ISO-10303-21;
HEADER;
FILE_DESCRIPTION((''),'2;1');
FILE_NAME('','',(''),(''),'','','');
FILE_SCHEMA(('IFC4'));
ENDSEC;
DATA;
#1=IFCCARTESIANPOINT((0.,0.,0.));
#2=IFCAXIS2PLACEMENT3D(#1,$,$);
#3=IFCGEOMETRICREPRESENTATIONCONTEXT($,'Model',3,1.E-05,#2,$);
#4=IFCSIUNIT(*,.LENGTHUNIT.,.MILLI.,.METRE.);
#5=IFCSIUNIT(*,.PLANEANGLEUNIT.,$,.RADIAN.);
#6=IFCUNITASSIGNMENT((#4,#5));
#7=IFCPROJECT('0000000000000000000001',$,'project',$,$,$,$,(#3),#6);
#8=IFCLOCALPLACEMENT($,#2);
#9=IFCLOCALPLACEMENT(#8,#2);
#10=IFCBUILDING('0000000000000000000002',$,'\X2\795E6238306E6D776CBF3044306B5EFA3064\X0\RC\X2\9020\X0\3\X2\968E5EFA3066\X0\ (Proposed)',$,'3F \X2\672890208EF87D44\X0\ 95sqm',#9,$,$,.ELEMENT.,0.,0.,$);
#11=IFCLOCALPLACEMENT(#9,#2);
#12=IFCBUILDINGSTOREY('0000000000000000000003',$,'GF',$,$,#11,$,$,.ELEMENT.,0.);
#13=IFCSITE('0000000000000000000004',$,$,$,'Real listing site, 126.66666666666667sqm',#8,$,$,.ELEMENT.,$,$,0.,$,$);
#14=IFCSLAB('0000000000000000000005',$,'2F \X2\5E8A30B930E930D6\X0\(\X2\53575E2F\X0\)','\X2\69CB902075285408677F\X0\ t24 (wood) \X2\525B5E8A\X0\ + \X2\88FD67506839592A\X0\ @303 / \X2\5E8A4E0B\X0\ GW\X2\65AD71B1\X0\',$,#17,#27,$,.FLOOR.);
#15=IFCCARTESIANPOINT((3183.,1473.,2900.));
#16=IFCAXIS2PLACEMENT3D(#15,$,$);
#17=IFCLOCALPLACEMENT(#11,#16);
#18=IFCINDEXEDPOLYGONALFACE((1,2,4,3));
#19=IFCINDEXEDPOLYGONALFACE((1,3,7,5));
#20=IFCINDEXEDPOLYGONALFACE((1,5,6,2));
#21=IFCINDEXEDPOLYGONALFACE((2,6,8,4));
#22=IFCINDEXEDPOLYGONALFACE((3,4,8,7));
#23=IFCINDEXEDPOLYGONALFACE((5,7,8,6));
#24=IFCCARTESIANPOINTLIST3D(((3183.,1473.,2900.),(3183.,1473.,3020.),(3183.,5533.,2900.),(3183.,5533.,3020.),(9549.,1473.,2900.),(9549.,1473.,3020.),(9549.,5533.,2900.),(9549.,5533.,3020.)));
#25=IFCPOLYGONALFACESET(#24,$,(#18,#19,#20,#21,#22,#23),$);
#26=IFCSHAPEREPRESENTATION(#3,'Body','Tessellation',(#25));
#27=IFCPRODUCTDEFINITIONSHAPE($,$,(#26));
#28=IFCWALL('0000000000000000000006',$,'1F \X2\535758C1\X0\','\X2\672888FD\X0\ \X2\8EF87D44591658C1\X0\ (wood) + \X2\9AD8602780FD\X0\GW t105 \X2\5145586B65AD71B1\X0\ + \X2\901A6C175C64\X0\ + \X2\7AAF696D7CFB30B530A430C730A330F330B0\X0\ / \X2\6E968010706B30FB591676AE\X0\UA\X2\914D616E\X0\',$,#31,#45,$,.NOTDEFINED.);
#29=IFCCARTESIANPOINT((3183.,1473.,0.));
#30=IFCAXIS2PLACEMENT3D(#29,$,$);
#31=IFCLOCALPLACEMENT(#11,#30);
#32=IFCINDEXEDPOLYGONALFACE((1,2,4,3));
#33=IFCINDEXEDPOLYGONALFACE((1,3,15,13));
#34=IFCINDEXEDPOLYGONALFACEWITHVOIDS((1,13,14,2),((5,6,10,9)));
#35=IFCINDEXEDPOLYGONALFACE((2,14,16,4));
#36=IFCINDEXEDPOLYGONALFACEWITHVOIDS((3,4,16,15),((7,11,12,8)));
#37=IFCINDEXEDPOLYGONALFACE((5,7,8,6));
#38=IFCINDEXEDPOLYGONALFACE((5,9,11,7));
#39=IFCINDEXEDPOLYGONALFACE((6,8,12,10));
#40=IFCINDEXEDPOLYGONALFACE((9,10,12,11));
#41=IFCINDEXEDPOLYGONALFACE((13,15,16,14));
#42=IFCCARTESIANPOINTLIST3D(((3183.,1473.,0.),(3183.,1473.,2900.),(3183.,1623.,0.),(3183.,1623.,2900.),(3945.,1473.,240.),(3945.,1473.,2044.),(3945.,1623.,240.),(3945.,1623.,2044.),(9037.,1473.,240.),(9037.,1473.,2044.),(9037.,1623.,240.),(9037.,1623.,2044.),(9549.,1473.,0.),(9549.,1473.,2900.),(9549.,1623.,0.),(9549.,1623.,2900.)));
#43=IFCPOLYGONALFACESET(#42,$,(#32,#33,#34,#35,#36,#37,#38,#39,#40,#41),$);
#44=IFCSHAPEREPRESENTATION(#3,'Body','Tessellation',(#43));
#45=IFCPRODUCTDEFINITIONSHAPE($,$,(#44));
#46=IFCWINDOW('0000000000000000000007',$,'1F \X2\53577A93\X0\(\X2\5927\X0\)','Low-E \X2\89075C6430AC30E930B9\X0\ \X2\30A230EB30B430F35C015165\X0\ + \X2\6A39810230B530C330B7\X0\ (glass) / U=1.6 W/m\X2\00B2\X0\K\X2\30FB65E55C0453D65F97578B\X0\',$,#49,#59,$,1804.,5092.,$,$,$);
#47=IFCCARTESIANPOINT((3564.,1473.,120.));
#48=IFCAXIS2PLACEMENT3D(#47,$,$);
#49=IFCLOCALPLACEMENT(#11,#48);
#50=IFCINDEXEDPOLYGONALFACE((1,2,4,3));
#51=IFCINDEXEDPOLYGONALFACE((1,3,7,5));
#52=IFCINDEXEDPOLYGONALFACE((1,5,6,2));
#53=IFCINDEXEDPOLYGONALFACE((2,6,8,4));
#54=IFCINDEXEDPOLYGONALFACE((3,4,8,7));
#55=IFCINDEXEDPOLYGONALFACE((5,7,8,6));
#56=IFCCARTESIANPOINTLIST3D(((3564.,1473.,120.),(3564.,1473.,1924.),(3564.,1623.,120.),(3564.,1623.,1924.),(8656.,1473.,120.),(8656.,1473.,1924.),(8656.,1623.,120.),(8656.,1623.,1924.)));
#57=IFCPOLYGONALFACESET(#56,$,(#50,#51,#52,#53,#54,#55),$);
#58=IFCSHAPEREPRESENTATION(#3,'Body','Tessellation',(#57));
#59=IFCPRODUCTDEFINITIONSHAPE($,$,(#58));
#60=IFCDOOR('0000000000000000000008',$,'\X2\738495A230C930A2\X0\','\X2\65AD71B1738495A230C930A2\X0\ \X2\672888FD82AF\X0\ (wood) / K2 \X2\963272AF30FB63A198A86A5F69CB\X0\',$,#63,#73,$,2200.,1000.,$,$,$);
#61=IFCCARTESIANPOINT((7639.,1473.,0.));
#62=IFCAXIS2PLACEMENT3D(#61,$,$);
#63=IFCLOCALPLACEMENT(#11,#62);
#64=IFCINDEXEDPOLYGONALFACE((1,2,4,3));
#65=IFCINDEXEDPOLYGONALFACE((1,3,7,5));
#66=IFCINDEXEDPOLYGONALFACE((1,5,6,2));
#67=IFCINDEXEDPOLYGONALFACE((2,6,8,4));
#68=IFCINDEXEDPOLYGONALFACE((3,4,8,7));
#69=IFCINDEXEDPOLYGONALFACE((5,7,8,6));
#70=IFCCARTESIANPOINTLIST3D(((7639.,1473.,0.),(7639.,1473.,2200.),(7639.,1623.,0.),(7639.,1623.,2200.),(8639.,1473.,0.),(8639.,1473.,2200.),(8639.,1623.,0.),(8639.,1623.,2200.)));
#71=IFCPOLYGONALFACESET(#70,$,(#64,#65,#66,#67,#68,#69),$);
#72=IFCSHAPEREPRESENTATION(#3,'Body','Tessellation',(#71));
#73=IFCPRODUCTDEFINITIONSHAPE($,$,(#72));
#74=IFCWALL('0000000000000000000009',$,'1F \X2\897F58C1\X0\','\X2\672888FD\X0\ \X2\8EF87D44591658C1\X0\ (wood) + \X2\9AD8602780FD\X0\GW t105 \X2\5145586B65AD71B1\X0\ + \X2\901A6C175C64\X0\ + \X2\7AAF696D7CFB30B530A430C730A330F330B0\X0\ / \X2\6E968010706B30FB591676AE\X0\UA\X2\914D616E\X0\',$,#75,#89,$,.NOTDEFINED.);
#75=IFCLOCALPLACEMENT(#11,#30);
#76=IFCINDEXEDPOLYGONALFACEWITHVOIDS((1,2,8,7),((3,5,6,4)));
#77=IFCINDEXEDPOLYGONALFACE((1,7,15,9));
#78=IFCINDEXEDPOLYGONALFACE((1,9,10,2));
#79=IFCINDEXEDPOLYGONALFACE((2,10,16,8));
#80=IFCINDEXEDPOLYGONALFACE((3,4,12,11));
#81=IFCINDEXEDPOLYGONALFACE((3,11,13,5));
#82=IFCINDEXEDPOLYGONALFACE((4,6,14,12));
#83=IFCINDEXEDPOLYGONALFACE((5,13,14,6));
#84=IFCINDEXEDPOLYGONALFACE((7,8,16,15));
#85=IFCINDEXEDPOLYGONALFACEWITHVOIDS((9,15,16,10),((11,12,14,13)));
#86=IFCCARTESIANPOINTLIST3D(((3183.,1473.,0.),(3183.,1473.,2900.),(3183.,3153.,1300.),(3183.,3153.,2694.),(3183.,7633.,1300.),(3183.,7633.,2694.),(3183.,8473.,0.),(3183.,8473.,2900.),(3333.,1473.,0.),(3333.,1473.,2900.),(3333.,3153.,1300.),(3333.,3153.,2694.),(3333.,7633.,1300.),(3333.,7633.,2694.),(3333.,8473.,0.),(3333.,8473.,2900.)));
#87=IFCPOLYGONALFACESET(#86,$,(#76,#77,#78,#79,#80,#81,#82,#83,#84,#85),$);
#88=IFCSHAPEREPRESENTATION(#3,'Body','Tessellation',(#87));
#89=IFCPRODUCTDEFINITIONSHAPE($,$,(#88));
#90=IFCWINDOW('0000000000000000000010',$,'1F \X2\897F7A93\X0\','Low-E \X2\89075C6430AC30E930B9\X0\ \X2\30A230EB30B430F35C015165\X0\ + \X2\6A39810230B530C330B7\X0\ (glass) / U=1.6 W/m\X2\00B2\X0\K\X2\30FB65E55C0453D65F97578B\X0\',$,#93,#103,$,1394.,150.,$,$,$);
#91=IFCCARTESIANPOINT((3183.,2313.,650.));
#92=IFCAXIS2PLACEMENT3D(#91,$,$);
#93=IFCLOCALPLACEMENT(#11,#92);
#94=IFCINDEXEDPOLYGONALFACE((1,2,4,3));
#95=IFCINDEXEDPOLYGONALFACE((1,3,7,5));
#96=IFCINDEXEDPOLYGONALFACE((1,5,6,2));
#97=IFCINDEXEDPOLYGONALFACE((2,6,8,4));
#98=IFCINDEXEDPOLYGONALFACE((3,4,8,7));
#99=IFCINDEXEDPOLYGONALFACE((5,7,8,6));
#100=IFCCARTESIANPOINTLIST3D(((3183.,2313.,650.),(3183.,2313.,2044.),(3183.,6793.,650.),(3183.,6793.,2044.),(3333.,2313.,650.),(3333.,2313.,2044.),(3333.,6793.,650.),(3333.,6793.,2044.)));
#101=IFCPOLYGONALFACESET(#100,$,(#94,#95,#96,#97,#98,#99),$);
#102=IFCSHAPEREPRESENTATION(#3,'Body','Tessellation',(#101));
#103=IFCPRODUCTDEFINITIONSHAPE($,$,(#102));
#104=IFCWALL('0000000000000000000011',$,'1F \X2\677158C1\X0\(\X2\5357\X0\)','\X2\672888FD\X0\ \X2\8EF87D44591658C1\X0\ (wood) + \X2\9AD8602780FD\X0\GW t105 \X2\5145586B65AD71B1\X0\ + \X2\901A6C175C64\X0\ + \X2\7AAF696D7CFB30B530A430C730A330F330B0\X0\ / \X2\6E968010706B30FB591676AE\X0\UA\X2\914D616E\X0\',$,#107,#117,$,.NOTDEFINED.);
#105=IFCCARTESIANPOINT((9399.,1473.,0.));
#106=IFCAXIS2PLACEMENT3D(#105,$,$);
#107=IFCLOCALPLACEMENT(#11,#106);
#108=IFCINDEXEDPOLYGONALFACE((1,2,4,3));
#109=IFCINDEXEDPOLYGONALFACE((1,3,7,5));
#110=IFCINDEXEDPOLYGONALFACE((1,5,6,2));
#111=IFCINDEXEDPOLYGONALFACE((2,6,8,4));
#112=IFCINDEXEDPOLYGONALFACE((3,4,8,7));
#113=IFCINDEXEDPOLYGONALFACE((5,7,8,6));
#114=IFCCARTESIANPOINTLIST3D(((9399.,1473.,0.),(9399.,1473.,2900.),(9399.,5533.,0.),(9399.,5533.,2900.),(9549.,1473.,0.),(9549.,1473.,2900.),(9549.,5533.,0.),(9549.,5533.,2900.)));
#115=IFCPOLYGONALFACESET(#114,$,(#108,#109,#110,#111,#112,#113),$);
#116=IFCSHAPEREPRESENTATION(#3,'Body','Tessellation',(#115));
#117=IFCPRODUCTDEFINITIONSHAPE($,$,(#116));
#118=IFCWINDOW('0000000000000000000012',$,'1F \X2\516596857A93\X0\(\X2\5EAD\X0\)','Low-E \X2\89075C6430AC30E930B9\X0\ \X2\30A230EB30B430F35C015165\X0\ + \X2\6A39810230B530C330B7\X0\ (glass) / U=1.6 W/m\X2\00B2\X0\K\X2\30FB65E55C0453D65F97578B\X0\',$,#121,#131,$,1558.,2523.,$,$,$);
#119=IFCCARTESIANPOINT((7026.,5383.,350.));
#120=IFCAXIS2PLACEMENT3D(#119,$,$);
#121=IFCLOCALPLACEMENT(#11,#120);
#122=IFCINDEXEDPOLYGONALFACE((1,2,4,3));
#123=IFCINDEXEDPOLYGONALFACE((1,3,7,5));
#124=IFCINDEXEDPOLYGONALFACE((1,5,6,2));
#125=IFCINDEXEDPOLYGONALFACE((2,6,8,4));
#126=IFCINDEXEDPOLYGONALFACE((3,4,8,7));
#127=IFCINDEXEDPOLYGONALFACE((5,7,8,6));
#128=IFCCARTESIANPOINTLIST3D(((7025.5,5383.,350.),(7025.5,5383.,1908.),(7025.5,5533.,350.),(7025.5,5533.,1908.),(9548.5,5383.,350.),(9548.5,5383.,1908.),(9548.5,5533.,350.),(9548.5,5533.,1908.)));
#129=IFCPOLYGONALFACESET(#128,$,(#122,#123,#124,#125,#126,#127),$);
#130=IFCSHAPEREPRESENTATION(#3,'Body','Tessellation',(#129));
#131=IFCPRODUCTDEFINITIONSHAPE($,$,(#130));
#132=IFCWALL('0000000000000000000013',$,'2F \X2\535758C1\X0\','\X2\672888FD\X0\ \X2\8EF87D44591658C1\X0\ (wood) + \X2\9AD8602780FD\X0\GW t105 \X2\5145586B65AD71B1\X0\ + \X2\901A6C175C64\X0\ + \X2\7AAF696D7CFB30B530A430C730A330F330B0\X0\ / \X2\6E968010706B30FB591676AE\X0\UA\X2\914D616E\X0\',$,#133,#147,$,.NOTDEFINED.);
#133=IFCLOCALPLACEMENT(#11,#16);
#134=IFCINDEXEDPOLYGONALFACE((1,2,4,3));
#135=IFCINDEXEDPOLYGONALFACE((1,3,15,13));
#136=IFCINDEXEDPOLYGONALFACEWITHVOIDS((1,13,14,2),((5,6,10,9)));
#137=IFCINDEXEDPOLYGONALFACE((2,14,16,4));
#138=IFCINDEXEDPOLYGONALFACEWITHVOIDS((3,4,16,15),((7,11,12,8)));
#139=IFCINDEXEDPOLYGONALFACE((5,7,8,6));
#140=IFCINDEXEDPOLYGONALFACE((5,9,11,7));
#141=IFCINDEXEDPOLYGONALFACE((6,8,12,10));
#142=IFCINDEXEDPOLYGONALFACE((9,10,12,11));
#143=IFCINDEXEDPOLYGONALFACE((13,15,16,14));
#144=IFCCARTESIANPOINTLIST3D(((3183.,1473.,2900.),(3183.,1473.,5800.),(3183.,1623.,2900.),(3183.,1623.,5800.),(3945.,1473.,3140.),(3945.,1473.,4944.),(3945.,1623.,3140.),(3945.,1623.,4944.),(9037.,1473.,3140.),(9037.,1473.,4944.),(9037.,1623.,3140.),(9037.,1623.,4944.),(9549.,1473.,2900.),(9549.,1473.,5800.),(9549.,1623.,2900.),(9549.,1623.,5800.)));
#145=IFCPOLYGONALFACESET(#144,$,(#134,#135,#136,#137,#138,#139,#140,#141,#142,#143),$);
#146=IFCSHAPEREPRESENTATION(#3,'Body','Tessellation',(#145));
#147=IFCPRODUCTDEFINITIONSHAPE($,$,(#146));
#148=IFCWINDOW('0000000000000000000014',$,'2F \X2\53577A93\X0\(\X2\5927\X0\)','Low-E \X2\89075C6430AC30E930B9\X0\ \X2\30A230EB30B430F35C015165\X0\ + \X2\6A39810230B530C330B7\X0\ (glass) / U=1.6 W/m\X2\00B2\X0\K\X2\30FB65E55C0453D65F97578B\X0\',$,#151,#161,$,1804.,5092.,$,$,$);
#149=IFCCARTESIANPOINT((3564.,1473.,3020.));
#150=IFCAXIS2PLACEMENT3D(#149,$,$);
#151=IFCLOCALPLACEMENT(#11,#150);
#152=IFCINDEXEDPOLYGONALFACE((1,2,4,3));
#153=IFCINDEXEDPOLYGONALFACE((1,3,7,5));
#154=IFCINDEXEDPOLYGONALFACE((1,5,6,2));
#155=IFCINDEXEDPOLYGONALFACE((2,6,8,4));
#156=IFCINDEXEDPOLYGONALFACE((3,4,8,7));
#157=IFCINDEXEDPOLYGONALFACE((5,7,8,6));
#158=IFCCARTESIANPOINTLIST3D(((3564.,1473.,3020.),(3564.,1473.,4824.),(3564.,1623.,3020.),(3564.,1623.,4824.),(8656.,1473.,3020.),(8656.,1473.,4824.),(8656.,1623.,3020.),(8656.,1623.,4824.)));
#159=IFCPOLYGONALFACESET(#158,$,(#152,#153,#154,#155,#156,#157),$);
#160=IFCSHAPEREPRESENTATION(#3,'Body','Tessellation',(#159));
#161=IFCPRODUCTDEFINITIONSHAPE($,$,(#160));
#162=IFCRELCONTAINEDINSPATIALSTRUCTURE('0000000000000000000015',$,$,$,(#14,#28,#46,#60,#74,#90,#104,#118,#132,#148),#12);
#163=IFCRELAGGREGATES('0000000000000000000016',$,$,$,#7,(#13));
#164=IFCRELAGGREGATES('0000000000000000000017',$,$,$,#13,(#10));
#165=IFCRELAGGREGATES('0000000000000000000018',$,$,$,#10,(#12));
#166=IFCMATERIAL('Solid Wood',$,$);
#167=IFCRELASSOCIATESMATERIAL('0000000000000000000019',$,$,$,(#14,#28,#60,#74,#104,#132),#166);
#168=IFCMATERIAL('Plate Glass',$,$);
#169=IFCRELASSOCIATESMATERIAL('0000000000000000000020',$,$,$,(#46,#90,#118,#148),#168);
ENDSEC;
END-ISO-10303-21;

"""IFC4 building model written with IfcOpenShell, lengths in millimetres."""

from ifc_helpers import new_model, si_unit, frame, frame_2d, origin, place, context, project, spatial, rectangle, extrude, material, element, fill, save


model = new_model("IFC4")

# Units and contexts
model_context = context("Model", 3, precision=1e-05, world=origin())
ifc_project = project(units=[si_unit("LENGTHUNIT", "METRE", prefix="MILLI"), si_unit("PLANEANGLEUNIT", "RADIAN")], contexts=[model_context])

# Site, building, storey
site_placement = place(None, origin())
site = spatial("IfcSite", under=ifc_project, at=site_placement, ObjectType="Real listing site, 126.66666666666667sqm", CompositionType="ELEMENT", RefElevation=0.0)
building_placement = place(site_placement, origin())
building = spatial("IfcBuilding", under=site, at=building_placement, Name="神戸の海沿いに建つRC造3階建て (Proposed)", ObjectType="3F 木造軸組 95sqm", CompositionType="ELEMENT", ElevationOfRefHeight=0.0, ElevationOfTerrain=0.0)
storey_placement = place(building_placement, origin())
storey = spatial("IfcBuildingStorey", under=building, at=storey_placement, Name="GF", CompositionType="ELEMENT", Elevation=0.0)

# Slab
ifc_material_1 = material(Name="Solid Wood")
slab_1_placement = place(storey_placement, frame((3183.0, 1473.0, 2900.0)))
element("IfcSlab", 1, at=slab_1_placement, inside=storey, material=ifc_material_1, Name="2F 床スラブ(南帯)", Description="構造用合板 t24 (wood) 剛床 + 製材根太 @303 / 床下 GW断熱", PredefinedType="FLOOR", context=model_context, shape_type="SweptSolid", body=[
    extrude(rectangle(XDim=6366.0, YDim=4060.0, at=frame_2d((3183.0, 2030.0))), frame((3183.0, 1473.0, 2900.0)), (0.0, 0.0, 1.0), 120.0),
])

# Wall, openings, window, door
wall_1_placement = place(storey_placement, frame((3183.0, 1473.0, 0.0)))
wall_1 = element("IfcWall", 2, at=wall_1_placement, inside=storey, material=ifc_material_1, Name="1F 南壁", Description="木製 軸組外壁 (wood) + 高性能GW t105 充填断熱 + 通気層 + 窯業系サイディング / 準耐火・外皮UA配慮", PredefinedType="NOTDEFINED", context=model_context, shape_type="SweptSolid", body=[
    extrude(rectangle(XDim=6366.0, YDim=150.0, at=frame_2d((3183.0, 75.0))), frame((3183.0, 1473.0, 0.0)), (0.0, 0.0, 1.0), 2900.0),
])
opening_1_placement = place(storey_placement, frame((3564.0, 1473.0, 120.0)))
opening_1 = element("IfcOpeningElement", 3, at=opening_1_placement, cuts=wall_1, PredefinedType="NOTDEFINED", context=model_context, shape_type="SweptSolid", body=[
    extrude(rectangle(XDim=5092.0, YDim=150.0, at=frame_2d((2546.0, 75.0))), frame((3564.0, 1473.0, 120.0)), (0.0, 0.0, 1.0), 1804.0),
])
opening_2_placement = place(storey_placement, frame((7639.0, 1473.0, 0.0)))
opening_2 = element("IfcOpeningElement", 4, at=opening_2_placement, cuts=wall_1, PredefinedType="NOTDEFINED", context=model_context, shape_type="SweptSolid", body=[
    extrude(rectangle(XDim=1000.0, YDim=150.0, at=frame_2d((500.0, 75.0))), frame((7639.0, 1473.0, 0.0)), (0.0, 0.0, 1.0), 2200.0),
])
ifc_material_2 = material(Name="Plate Glass")
window_1_placement = place(storey_placement, frame((3564.0, 1473.0, 120.0)))
window_1 = element("IfcWindow", 5, at=window_1_placement, inside=storey, material=ifc_material_2, Name="1F 南窓(大)", Description="Low-E 複層ガラス アルゴン封入 + 樹脂サッシ (glass) / U=1.6 W/m²K・日射取得型", OverallHeight=1804.0, OverallWidth=5092.0, context=model_context, shape_type="SweptSolid", body=[
    extrude(rectangle(XDim=5092.0, YDim=150.0, at=frame_2d((2546.0, 75.0))), frame((3564.0, 1473.0, 120.0)), (0.0, 0.0, 1.0), 1804.0),
])
fill(opening_1, window_1)
door_placement = place(storey_placement, frame((7639.0, 1473.0, 0.0)))
door = element("IfcDoor", 6, at=door_placement, inside=storey, material=ifc_material_1, Name="玄関ドア", Description="断熱玄関ドア 木製芯 (wood) / K2 防犯・採風機構", OverallHeight=2200.0, OverallWidth=1000.0, context=model_context, shape_type="SweptSolid", body=[
    extrude(rectangle(XDim=1000.0, YDim=150.0, at=frame_2d((500.0, 75.0))), frame((7639.0, 1473.0, 0.0)), (0.0, 0.0, 1.0), 2200.0),
])
fill(opening_2, door)

# Walls, openings, windows
wall_2_placement = place(storey_placement, frame((3183.0, 1473.0, 0.0)))
wall_2 = element("IfcWall", 7, at=wall_2_placement, inside=storey, material=ifc_material_1, Name="1F 西壁", Description="木製 軸組外壁 (wood) + 高性能GW t105 充填断熱 + 通気層 + 窯業系サイディング / 準耐火・外皮UA配慮", PredefinedType="NOTDEFINED", context=model_context, shape_type="SweptSolid", body=[
    extrude(rectangle(XDim=150.0, YDim=7000.0, at=frame_2d((75.0, 3500.0))), frame((3183.0, 1473.0, 0.0)), (0.0, 0.0, 1.0), 2900.0),
])
opening_3_placement = place(storey_placement, frame((3183.0, 2313.0, 650.0)))
opening_3 = element("IfcOpeningElement", 8, at=opening_3_placement, cuts=wall_2, PredefinedType="NOTDEFINED", context=model_context, shape_type="SweptSolid", body=[
    extrude(rectangle(XDim=150.0, YDim=4480.0, at=frame_2d((75.0, 2240.0))), frame((3183.0, 2313.0, 650.0)), (0.0, 0.0, 1.0), 1394.0),
])
window_2_placement = place(storey_placement, frame((3183.0, 2313.0, 650.0)))
window_2 = element("IfcWindow", 9, at=window_2_placement, inside=storey, material=ifc_material_2, Name="1F 西窓", Description="Low-E 複層ガラス アルゴン封入 + 樹脂サッシ (glass) / U=1.6 W/m²K・日射取得型", OverallHeight=1394.0, OverallWidth=150.0, context=model_context, shape_type="SweptSolid", body=[
    extrude(rectangle(XDim=150.0, YDim=4480.0, at=frame_2d((75.0, 2240.0))), frame((3183.0, 2313.0, 650.0)), (0.0, 0.0, 1.0), 1394.0),
])
fill(opening_3, window_2)
wall_3_placement = place(storey_placement, frame((9399.0, 1473.0, 0.0)))
wall_3 = element("IfcWall", 10, at=wall_3_placement, inside=storey, material=ifc_material_1, Name="1F 東壁(南)", Description="木製 軸組外壁 (wood) + 高性能GW t105 充填断熱 + 通気層 + 窯業系サイディング / 準耐火・外皮UA配慮", PredefinedType="NOTDEFINED", context=model_context, shape_type="SweptSolid", body=[
    extrude(rectangle(XDim=150.0, YDim=4060.0, at=frame_2d((75.0, 2030.0))), frame((9399.0, 1473.0, 0.0)), (0.0, 0.0, 1.0), 2900.0),
])
opening_4_placement = place(storey_placement, frame((7026.0, 5383.0, 350.0)))
opening_4 = element("IfcOpeningElement", 11, at=opening_4_placement, cuts=wall_3, PredefinedType="NOTDEFINED", context=model_context, shape_type="SweptSolid", body=[
    extrude(rectangle(XDim=2523.0, YDim=150.0, at=frame_2d((1261.0, 75.0))), frame((7026.0, 5383.0, 350.0)), (0.0, 0.0, 1.0), 1558.0),
])
window_3_placement = place(storey_placement, frame((7026.0, 5383.0, 350.0)))
window_3 = element("IfcWindow", 12, at=window_3_placement, inside=storey, material=ifc_material_2, Name="1F 入隅窓(庭)", Description="Low-E 複層ガラス アルゴン封入 + 樹脂サッシ (glass) / U=1.6 W/m²K・日射取得型", OverallHeight=1558.0, OverallWidth=2523.0, context=model_context, shape_type="SweptSolid", body=[
    extrude(rectangle(XDim=2523.0, YDim=150.0, at=frame_2d((1261.0, 75.0))), frame((7026.0, 5383.0, 350.0)), (0.0, 0.0, 1.0), 1558.0),
])
fill(opening_4, window_3)

# Wall, opening, window
wall_4_placement = place(storey_placement, frame((3183.0, 1473.0, 2900.0)))
wall_4 = element("IfcWall", 13, at=wall_4_placement, inside=storey, material=ifc_material_1, Name="2F 南壁", Description="木製 軸組外壁 (wood) + 高性能GW t105 充填断熱 + 通気層 + 窯業系サイディング / 準耐火・外皮UA配慮", PredefinedType="NOTDEFINED", context=model_context, shape_type="SweptSolid", body=[
    extrude(rectangle(XDim=6366.0, YDim=150.0, at=frame_2d((3183.0, 75.0))), frame((3183.0, 1473.0, 2900.0)), (0.0, 0.0, 1.0), 2900.0),
])
opening_5_placement = place(storey_placement, frame((3564.0, 1473.0, 3020.0)))
opening_5 = element("IfcOpeningElement", 14, at=opening_5_placement, cuts=wall_4, PredefinedType="NOTDEFINED", context=model_context, shape_type="SweptSolid", body=[
    extrude(rectangle(XDim=5092.0, YDim=150.0, at=frame_2d((2546.0, 75.0))), frame((3564.0, 1473.0, 3020.0)), (0.0, 0.0, 1.0), 1804.0),
])
window_4_placement = place(storey_placement, frame((3564.0, 1473.0, 3020.0)))
window_4 = element("IfcWindow", 15, at=window_4_placement, inside=storey, material=ifc_material_2, Name="2F 南窓(大)", Description="Low-E 複層ガラス アルゴン封入 + 樹脂サッシ (glass) / U=1.6 W/m²K・日射取得型", OverallHeight=1804.0, OverallWidth=5092.0, context=model_context, shape_type="SweptSolid", body=[
    extrude(rectangle(XDim=5092.0, YDim=150.0, at=frame_2d((2546.0, 75.0))), frame((3564.0, 1473.0, 3020.0)), (0.0, 0.0, 1.0), 1804.0),
])
fill(opening_5, window_4)

save(model, "model.ifc")
